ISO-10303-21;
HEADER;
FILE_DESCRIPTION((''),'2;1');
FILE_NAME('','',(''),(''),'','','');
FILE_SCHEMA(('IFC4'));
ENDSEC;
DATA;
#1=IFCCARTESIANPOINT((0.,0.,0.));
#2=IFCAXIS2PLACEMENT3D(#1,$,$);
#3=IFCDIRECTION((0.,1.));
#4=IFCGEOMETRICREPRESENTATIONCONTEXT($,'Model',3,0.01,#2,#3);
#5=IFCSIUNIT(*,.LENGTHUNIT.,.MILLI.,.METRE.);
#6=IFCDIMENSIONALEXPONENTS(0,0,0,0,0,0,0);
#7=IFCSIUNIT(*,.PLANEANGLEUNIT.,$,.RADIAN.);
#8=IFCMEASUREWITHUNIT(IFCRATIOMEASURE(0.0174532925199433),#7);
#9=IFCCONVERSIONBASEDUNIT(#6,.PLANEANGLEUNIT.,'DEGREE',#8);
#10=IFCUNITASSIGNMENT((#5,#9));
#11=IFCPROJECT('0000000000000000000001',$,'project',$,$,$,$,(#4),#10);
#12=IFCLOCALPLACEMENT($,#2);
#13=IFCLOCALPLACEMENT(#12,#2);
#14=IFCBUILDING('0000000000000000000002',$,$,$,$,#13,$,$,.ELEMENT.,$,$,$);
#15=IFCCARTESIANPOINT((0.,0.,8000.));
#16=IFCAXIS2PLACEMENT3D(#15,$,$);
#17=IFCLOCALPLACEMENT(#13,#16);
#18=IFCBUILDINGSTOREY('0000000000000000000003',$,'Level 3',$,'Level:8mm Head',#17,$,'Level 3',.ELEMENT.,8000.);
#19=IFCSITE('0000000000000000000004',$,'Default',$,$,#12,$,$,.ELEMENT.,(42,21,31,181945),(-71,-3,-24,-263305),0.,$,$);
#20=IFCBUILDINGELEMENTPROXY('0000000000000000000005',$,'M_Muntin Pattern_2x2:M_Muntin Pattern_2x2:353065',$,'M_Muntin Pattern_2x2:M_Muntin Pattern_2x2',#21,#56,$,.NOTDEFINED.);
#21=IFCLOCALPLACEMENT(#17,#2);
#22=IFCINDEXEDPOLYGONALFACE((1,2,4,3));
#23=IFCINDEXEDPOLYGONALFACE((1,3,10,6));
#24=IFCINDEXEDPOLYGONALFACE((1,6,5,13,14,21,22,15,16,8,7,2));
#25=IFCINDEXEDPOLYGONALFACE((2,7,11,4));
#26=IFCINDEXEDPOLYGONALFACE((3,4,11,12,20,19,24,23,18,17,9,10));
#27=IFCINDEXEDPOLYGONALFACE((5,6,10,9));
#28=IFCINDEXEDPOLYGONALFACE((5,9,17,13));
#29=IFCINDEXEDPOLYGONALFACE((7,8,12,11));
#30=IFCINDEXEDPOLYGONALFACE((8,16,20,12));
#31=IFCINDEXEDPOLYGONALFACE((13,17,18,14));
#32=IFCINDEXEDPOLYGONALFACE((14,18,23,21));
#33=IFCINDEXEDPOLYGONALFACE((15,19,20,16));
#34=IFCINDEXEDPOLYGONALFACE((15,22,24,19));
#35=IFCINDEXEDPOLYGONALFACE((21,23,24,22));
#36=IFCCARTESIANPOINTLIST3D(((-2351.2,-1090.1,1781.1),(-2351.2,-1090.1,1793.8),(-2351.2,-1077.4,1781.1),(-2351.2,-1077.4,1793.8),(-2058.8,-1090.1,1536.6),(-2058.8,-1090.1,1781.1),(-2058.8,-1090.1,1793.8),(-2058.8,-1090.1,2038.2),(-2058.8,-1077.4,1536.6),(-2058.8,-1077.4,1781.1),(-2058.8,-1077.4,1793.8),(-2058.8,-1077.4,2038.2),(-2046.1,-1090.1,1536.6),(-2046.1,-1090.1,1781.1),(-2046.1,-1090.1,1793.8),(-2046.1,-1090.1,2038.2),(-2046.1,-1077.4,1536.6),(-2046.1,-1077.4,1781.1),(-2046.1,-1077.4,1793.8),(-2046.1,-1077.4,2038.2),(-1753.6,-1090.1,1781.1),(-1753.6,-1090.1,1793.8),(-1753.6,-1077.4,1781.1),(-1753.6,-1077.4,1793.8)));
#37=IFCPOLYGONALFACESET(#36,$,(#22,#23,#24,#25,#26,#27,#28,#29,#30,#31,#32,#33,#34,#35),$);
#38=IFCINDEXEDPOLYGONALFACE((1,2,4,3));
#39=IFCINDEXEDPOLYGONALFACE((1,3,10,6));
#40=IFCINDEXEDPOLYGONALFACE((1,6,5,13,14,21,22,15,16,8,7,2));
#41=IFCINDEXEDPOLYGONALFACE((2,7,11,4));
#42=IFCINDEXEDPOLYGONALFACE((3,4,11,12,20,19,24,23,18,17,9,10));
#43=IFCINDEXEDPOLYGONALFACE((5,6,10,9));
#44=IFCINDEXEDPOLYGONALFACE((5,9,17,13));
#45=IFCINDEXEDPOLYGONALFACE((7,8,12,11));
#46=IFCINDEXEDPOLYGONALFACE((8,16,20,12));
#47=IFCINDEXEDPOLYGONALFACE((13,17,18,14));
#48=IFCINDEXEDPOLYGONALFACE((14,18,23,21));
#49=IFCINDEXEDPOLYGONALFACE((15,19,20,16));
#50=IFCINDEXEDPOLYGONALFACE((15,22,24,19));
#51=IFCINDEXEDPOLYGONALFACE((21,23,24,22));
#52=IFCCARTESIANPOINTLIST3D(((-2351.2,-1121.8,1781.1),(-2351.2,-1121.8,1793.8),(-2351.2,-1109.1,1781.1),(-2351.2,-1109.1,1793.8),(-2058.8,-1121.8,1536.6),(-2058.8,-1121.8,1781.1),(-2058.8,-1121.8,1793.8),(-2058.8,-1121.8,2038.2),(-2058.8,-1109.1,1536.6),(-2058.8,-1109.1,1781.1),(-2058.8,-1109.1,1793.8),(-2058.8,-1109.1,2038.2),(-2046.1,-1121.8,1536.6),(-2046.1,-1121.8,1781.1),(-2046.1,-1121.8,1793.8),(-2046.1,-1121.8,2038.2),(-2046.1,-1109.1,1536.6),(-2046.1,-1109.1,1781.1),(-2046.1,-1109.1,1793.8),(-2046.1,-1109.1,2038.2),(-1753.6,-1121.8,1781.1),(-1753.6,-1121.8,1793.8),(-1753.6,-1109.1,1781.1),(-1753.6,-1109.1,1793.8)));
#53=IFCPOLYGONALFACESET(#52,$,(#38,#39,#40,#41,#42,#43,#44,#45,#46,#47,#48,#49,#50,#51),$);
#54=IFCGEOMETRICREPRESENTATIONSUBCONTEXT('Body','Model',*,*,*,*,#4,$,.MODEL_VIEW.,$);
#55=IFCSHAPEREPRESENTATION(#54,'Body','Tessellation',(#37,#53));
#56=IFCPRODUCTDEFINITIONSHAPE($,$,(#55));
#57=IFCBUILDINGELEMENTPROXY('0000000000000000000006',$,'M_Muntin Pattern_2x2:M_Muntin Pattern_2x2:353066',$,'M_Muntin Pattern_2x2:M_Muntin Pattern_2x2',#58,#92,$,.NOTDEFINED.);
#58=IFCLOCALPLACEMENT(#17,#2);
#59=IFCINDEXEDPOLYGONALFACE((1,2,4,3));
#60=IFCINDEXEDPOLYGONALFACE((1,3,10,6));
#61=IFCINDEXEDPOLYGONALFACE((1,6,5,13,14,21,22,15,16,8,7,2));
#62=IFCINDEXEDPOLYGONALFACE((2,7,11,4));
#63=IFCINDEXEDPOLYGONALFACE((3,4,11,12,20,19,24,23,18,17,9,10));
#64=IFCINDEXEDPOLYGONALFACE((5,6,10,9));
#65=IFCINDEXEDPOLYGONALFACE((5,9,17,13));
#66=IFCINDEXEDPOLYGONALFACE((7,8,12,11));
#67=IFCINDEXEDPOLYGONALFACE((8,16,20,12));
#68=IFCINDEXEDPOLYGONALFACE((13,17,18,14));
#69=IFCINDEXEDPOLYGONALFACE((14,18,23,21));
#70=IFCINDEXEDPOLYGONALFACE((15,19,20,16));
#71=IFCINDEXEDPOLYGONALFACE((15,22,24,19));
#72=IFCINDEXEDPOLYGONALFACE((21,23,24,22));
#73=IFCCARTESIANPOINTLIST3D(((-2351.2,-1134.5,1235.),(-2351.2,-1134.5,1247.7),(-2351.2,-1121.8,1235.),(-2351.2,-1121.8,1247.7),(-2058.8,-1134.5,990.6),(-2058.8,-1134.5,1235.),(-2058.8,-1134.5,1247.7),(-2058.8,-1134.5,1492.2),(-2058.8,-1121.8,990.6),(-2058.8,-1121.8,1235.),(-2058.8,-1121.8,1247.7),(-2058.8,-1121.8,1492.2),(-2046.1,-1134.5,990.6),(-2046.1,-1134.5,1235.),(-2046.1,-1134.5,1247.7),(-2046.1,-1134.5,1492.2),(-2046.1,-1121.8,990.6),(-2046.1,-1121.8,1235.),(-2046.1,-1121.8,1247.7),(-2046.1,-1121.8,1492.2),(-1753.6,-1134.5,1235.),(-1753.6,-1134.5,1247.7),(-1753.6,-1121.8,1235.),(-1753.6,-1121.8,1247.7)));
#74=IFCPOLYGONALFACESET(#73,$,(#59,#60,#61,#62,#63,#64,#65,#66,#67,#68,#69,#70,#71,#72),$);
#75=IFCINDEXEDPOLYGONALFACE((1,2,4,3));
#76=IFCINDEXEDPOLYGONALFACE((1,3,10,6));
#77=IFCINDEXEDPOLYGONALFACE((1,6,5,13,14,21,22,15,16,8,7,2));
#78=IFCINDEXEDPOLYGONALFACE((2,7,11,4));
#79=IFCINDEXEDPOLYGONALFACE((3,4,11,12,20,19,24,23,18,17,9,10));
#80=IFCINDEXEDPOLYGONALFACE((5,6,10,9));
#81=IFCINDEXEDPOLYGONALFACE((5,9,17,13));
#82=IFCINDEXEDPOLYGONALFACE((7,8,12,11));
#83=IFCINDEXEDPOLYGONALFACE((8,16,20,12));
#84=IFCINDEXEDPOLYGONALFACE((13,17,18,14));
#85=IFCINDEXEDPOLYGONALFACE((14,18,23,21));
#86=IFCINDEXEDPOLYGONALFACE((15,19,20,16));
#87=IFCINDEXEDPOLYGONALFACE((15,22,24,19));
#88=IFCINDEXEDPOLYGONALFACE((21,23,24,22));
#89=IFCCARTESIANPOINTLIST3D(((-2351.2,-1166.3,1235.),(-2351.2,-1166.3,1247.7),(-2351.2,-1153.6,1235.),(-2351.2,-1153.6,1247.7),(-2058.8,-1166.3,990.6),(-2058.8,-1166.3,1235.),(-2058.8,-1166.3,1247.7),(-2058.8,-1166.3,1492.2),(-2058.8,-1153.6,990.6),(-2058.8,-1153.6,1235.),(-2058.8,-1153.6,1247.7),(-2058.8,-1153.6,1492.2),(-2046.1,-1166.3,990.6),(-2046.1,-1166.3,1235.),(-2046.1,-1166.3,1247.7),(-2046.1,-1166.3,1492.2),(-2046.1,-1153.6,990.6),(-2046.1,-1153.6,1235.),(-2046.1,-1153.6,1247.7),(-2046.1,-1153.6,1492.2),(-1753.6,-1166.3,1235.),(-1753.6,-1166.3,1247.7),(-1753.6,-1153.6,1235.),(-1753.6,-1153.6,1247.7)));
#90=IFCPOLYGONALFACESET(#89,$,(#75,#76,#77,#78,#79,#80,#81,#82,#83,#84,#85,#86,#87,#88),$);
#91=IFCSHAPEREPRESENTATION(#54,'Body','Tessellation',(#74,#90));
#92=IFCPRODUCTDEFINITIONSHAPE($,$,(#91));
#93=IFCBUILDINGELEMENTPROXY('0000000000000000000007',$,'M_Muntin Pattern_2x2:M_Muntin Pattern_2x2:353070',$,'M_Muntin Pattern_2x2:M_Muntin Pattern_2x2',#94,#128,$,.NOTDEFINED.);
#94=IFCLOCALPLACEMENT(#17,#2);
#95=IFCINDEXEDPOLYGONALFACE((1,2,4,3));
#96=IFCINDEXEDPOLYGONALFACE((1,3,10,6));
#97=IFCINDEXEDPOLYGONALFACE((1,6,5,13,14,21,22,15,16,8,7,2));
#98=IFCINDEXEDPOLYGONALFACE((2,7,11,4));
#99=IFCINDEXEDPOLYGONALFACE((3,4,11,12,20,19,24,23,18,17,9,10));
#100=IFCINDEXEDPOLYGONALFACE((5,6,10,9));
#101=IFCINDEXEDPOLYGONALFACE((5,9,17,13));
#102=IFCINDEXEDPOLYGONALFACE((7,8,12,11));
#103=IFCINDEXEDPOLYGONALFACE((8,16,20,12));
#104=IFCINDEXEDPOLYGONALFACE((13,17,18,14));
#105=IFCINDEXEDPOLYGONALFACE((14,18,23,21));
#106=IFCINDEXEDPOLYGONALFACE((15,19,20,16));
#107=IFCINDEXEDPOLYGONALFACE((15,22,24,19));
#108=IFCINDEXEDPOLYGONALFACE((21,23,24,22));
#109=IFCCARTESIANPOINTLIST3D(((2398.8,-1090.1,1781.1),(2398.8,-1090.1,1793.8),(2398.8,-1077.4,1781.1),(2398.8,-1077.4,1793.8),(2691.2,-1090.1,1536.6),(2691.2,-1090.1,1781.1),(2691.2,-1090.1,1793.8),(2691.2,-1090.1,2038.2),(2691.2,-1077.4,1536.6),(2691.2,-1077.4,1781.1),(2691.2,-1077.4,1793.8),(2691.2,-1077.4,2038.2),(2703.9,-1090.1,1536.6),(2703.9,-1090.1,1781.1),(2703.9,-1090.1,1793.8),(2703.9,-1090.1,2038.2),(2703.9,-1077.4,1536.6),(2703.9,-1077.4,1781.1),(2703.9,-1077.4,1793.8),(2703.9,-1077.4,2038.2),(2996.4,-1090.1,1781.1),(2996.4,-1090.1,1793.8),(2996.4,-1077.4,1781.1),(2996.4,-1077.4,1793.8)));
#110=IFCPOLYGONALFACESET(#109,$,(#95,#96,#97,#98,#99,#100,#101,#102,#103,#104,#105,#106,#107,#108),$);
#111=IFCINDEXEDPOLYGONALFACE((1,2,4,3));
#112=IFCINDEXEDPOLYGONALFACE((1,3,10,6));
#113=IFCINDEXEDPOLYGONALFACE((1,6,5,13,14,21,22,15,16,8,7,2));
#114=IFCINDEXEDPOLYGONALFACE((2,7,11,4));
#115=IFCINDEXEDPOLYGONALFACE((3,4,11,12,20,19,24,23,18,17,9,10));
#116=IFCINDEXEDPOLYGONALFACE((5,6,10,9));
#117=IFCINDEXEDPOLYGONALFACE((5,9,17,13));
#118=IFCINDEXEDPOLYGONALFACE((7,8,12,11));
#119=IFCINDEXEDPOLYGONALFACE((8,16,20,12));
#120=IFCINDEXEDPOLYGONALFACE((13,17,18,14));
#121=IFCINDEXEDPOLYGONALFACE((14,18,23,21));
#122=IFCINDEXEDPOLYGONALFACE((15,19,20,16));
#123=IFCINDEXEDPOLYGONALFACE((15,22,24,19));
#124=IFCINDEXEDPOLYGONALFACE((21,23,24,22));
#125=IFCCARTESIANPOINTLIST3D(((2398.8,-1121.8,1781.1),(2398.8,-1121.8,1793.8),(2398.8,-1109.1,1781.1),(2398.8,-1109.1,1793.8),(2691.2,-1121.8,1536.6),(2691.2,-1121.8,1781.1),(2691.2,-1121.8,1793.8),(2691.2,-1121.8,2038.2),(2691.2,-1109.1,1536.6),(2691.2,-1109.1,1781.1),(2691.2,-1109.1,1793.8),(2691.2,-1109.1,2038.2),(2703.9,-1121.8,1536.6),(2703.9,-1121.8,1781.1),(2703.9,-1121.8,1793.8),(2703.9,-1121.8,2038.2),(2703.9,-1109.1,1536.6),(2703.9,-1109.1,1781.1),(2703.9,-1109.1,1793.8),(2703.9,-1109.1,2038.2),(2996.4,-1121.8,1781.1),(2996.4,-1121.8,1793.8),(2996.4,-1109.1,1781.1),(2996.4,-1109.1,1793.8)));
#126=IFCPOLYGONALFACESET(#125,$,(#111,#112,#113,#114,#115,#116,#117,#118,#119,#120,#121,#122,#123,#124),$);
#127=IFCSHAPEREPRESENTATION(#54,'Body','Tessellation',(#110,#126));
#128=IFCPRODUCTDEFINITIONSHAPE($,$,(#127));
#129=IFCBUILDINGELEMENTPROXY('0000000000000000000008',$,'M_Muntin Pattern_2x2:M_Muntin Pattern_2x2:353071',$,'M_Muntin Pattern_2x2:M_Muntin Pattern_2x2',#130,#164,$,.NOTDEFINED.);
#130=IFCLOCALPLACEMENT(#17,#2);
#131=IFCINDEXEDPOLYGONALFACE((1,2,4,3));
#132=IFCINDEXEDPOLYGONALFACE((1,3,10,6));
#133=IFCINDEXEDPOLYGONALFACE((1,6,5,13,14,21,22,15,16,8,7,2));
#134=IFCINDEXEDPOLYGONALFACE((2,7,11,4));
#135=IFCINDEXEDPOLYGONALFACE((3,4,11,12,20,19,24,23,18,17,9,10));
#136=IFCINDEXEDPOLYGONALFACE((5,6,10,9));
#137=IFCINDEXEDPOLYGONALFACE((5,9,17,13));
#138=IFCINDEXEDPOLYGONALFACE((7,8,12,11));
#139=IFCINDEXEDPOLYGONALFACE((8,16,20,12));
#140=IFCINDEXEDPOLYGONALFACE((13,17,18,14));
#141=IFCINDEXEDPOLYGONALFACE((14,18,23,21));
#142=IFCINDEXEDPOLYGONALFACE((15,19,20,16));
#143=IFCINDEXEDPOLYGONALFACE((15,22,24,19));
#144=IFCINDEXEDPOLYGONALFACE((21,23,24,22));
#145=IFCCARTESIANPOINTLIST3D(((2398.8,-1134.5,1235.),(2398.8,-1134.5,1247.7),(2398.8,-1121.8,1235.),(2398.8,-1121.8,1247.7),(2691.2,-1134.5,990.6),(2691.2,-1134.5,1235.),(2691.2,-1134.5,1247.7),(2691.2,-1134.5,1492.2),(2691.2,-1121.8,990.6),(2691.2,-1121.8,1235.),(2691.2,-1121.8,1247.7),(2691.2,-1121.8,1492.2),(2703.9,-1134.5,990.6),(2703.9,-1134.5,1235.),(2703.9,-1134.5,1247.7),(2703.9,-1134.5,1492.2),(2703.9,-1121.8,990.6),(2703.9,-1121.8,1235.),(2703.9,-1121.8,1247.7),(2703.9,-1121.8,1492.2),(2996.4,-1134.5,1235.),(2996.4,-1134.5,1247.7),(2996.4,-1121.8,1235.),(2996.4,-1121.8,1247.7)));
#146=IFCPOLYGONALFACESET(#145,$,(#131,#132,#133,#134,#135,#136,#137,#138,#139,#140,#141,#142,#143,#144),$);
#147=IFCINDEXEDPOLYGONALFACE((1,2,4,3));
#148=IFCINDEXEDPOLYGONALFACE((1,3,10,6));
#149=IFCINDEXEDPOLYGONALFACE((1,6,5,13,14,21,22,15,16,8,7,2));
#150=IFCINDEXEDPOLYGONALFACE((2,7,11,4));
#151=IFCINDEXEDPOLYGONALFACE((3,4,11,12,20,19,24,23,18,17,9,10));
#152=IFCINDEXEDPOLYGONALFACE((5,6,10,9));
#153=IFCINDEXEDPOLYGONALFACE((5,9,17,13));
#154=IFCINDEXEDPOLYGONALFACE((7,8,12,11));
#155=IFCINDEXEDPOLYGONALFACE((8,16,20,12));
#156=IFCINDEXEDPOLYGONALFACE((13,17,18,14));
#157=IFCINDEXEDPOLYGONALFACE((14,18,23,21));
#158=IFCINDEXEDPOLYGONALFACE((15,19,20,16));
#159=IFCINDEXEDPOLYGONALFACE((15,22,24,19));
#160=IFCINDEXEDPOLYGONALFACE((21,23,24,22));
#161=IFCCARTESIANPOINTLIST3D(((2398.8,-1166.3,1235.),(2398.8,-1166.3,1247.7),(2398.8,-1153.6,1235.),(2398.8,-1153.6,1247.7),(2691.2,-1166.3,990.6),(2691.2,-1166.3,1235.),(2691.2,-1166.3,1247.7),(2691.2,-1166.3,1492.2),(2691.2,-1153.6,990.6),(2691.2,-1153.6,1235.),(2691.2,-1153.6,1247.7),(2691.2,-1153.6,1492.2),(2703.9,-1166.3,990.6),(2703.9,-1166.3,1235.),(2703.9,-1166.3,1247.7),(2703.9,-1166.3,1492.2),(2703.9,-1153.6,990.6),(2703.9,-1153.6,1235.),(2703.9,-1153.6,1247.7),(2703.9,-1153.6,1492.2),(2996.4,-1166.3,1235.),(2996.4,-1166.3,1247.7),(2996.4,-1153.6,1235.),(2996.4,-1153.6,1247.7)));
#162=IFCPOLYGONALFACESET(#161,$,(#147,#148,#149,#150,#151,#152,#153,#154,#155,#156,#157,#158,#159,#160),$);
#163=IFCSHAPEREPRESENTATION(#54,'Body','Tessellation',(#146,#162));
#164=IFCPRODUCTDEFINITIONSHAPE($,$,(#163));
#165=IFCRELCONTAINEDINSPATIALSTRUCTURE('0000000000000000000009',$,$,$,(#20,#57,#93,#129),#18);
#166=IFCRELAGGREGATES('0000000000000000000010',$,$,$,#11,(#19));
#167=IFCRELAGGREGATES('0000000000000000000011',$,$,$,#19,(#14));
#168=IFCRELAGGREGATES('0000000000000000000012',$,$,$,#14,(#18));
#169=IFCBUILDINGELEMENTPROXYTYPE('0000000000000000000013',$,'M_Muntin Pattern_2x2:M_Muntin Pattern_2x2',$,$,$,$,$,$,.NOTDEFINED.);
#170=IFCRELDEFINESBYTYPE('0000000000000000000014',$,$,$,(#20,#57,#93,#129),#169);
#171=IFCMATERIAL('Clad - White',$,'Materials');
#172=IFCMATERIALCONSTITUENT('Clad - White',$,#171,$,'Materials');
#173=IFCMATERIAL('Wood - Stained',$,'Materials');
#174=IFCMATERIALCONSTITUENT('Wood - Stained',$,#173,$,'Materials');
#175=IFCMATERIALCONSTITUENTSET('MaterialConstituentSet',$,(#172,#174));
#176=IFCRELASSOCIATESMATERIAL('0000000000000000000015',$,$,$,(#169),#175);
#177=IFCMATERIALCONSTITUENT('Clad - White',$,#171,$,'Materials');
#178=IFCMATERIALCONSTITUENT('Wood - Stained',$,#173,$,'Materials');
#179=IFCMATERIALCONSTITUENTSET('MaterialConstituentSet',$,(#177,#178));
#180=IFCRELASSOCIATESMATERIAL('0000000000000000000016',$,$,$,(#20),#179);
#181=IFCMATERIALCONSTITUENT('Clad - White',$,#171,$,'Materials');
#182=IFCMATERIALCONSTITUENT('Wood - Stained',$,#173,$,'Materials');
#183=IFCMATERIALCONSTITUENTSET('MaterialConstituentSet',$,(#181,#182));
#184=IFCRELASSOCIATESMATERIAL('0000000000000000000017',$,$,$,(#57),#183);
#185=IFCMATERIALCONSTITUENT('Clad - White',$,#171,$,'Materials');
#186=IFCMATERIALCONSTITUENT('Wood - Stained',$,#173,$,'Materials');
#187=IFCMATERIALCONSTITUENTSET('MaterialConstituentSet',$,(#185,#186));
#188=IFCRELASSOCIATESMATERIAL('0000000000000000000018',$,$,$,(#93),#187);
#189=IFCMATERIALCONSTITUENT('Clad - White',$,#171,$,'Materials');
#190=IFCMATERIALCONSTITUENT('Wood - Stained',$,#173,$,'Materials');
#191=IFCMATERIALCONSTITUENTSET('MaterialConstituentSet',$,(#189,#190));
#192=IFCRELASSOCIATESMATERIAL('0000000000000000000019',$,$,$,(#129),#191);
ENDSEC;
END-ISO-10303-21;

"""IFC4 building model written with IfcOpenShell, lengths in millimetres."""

from ifc_helpers import new_model, entity, si_unit, converted_unit, direction, frame, origin, place, context, subcontext, project, spatial, polyline, outline, extrude, source, transform, mapped, material, constituent, constituent_set, type_object, type_shapes, element, save


model = new_model("IFC4")

# Units and contexts
model_context = context("Model", 3, precision=0.01, world=origin(), true_north=direction((0.0, 1.0)))
body_context = subcontext(model_context, "Body", "Model", "MODEL_VIEW")
ifc_project = project(units=[si_unit("LENGTHUNIT", "METRE", prefix="MILLI"), converted_unit("PLANEANGLEUNIT", "DEGREE", entity("IfcRatioMeasure", 0.0174532925199433), si_unit("PLANEANGLEUNIT", "RADIAN"), dimensions=[0, 0, 0, 0, 0, 0, 0])], contexts=[model_context])

# Site, building, storey
site_placement = place(None, origin())
site = spatial("IfcSite", under=ifc_project, at=site_placement, Name="Default", CompositionType="ELEMENT", RefLatitude=(42, 21, 31, 181945), RefLongitude=(-71, -3, -24, -263305), RefElevation=0.0)
building_placement = place(site_placement, origin())
building = spatial("IfcBuilding", under=site, at=building_placement, CompositionType="ELEMENT")
storey_placement = place(building_placement, frame((0.0, 0.0, 8000.0)))
storey = spatial("IfcBuildingStorey", under=building, at=storey_placement, Name="Level 3", ObjectType="Level:8mm Head", LongName="Level 3", CompositionType="ELEMENT", Elevation=8000.0)

# Shared definitions
ifc_material_1 = material(Name="Wood - Stained", Category="Materials")

# Building element proxies
ifc_material_2 = material(Name="Clad - White", Category="Materials")
ifc_constituent_1 = constituent(ifc_material_2, Name="Clad - White", Category="Materials")
ifc_constituent_2 = constituent(ifc_material_1, Name="Wood - Stained", Category="Materials")
ifc_constituent_set_1 = constituent_set(constituents=[ifc_constituent_1, ifc_constituent_2], Name="MaterialConstituentSet")
ifc_constituent_3 = constituent(ifc_material_2, Name="Clad - White", Category="Materials")
ifc_constituent_4 = constituent(ifc_material_1, Name="Wood - Stained", Category="Materials")
ifc_constituent_set_2 = constituent_set(constituents=[ifc_constituent_3, ifc_constituent_4], Name="MaterialConstituentSet")
building_element_proxy_type_1 = type_object("IfcBuildingElementProxyType", Name="M_Muntin Pattern_2x2:M_Muntin Pattern_2x2", PredefinedType="NOTDEFINED", material=ifc_constituent_set_2)
shared_shape_1 = source(origin(), body_context, "Body", "SweptSolid", [
    extrude(outline(polyline([(6.4, -6.4), (250.8, -6.4), (250.8, 6.3), (6.4, 6.3), (6.4, 298.8), (-6.3, 298.8), (-6.3, 6.3), (-250.8, 6.3), (-250.8, -6.4), (-6.3, -6.4), (-6.3, -298.8), (6.4, -298.8), (6.4, -6.4)])), frame((0.0, 9.5, 250.8), z_axis=(0.0, 1.0, 0.0), x_axis=(0.0, 0.0, 1.0)), (0.0, 0.0, 1.0), 12.7),
    extrude(outline(polyline([(6.4, -6.4), (250.8, -6.4), (250.8, 6.3), (6.4, 6.3), (6.4, 298.8), (-6.3, 298.8), (-6.3, 6.3), (-250.8, 6.3), (-250.8, -6.4), (-6.3, -6.4), (-6.3, -298.8), (6.4, -298.8), (6.4, -6.4)])), frame((0.0, -22.2, 250.8), z_axis=(0.0, 1.0, 0.0), x_axis=(0.0, 0.0, 1.0)), (0.0, 0.0, 1.0), 12.7),
])
type_shapes(building_element_proxy_type_1, [shared_shape_1])
proxy_1_placement = place(storey_placement, frame((-2052.4, -1099.6, 1536.6)))
element("IfcBuildingElementProxy", 1, at=proxy_1_placement, inside=storey, type_object=building_element_proxy_type_1, material=ifc_constituent_set_1, Name="M_Muntin Pattern_2x2:M_Muntin Pattern_2x2:353065", ObjectType="M_Muntin Pattern_2x2:M_Muntin Pattern_2x2", PredefinedType="NOTDEFINED", context=body_context, shape_type="MappedRepresentation", body=[
    mapped(shared_shape_1, transform((0.0, 0.0, 0.0), scale=1.0)),
])
ifc_constituent_5 = constituent(ifc_material_2, Name="Clad - White", Category="Materials")
ifc_constituent_6 = constituent(ifc_material_1, Name="Wood - Stained", Category="Materials")
ifc_constituent_set_3 = constituent_set(constituents=[ifc_constituent_5, ifc_constituent_6], Name="MaterialConstituentSet")
proxy_2_placement = place(storey_placement, frame((-2052.4, -1144.0, 990.6)))
element("IfcBuildingElementProxy", 2, at=proxy_2_placement, inside=storey, type_object=building_element_proxy_type_1, material=ifc_constituent_set_3, Name="M_Muntin Pattern_2x2:M_Muntin Pattern_2x2:353066", ObjectType="M_Muntin Pattern_2x2:M_Muntin Pattern_2x2", PredefinedType="NOTDEFINED", context=body_context, shape_type="MappedRepresentation", body=[
    mapped(shared_shape_1, transform((0.0, 0.0, 0.0), scale=1.0)),
])
ifc_constituent_7 = constituent(ifc_material_2, Name="Clad - White", Category="Materials")
ifc_constituent_8 = constituent(ifc_material_1, Name="Wood - Stained", Category="Materials")
ifc_constituent_set_4 = constituent_set(constituents=[ifc_constituent_7, ifc_constituent_8], Name="MaterialConstituentSet")
proxy_3_placement = place(storey_placement, frame((2697.6, -1099.6, 1536.6)))
element("IfcBuildingElementProxy", 3, at=proxy_3_placement, inside=storey, type_object=building_element_proxy_type_1, material=ifc_constituent_set_4, Name="M_Muntin Pattern_2x2:M_Muntin Pattern_2x2:353070", ObjectType="M_Muntin Pattern_2x2:M_Muntin Pattern_2x2", PredefinedType="NOTDEFINED", context=body_context, shape_type="MappedRepresentation", body=[
    mapped(shared_shape_1, transform((0.0, 0.0, 0.0), scale=1.0)),
])
ifc_constituent_9 = constituent(ifc_material_2, Name="Clad - White", Category="Materials")
ifc_constituent_10 = constituent(ifc_material_1, Name="Wood - Stained", Category="Materials")
ifc_constituent_set_5 = constituent_set(constituents=[ifc_constituent_9, ifc_constituent_10], Name="MaterialConstituentSet")
proxy_4_placement = place(storey_placement, frame((2697.6, -1144.0, 990.6)))
element("IfcBuildingElementProxy", 4, at=proxy_4_placement, inside=storey, type_object=building_element_proxy_type_1, material=ifc_constituent_set_5, Name="M_Muntin Pattern_2x2:M_Muntin Pattern_2x2:353071", ObjectType="M_Muntin Pattern_2x2:M_Muntin Pattern_2x2", PredefinedType="NOTDEFINED", context=body_context, shape_type="MappedRepresentation", body=[
    mapped(shared_shape_1, transform((0.0, 0.0, 0.0), scale=1.0)),
])

save(model, "model.ifc")
